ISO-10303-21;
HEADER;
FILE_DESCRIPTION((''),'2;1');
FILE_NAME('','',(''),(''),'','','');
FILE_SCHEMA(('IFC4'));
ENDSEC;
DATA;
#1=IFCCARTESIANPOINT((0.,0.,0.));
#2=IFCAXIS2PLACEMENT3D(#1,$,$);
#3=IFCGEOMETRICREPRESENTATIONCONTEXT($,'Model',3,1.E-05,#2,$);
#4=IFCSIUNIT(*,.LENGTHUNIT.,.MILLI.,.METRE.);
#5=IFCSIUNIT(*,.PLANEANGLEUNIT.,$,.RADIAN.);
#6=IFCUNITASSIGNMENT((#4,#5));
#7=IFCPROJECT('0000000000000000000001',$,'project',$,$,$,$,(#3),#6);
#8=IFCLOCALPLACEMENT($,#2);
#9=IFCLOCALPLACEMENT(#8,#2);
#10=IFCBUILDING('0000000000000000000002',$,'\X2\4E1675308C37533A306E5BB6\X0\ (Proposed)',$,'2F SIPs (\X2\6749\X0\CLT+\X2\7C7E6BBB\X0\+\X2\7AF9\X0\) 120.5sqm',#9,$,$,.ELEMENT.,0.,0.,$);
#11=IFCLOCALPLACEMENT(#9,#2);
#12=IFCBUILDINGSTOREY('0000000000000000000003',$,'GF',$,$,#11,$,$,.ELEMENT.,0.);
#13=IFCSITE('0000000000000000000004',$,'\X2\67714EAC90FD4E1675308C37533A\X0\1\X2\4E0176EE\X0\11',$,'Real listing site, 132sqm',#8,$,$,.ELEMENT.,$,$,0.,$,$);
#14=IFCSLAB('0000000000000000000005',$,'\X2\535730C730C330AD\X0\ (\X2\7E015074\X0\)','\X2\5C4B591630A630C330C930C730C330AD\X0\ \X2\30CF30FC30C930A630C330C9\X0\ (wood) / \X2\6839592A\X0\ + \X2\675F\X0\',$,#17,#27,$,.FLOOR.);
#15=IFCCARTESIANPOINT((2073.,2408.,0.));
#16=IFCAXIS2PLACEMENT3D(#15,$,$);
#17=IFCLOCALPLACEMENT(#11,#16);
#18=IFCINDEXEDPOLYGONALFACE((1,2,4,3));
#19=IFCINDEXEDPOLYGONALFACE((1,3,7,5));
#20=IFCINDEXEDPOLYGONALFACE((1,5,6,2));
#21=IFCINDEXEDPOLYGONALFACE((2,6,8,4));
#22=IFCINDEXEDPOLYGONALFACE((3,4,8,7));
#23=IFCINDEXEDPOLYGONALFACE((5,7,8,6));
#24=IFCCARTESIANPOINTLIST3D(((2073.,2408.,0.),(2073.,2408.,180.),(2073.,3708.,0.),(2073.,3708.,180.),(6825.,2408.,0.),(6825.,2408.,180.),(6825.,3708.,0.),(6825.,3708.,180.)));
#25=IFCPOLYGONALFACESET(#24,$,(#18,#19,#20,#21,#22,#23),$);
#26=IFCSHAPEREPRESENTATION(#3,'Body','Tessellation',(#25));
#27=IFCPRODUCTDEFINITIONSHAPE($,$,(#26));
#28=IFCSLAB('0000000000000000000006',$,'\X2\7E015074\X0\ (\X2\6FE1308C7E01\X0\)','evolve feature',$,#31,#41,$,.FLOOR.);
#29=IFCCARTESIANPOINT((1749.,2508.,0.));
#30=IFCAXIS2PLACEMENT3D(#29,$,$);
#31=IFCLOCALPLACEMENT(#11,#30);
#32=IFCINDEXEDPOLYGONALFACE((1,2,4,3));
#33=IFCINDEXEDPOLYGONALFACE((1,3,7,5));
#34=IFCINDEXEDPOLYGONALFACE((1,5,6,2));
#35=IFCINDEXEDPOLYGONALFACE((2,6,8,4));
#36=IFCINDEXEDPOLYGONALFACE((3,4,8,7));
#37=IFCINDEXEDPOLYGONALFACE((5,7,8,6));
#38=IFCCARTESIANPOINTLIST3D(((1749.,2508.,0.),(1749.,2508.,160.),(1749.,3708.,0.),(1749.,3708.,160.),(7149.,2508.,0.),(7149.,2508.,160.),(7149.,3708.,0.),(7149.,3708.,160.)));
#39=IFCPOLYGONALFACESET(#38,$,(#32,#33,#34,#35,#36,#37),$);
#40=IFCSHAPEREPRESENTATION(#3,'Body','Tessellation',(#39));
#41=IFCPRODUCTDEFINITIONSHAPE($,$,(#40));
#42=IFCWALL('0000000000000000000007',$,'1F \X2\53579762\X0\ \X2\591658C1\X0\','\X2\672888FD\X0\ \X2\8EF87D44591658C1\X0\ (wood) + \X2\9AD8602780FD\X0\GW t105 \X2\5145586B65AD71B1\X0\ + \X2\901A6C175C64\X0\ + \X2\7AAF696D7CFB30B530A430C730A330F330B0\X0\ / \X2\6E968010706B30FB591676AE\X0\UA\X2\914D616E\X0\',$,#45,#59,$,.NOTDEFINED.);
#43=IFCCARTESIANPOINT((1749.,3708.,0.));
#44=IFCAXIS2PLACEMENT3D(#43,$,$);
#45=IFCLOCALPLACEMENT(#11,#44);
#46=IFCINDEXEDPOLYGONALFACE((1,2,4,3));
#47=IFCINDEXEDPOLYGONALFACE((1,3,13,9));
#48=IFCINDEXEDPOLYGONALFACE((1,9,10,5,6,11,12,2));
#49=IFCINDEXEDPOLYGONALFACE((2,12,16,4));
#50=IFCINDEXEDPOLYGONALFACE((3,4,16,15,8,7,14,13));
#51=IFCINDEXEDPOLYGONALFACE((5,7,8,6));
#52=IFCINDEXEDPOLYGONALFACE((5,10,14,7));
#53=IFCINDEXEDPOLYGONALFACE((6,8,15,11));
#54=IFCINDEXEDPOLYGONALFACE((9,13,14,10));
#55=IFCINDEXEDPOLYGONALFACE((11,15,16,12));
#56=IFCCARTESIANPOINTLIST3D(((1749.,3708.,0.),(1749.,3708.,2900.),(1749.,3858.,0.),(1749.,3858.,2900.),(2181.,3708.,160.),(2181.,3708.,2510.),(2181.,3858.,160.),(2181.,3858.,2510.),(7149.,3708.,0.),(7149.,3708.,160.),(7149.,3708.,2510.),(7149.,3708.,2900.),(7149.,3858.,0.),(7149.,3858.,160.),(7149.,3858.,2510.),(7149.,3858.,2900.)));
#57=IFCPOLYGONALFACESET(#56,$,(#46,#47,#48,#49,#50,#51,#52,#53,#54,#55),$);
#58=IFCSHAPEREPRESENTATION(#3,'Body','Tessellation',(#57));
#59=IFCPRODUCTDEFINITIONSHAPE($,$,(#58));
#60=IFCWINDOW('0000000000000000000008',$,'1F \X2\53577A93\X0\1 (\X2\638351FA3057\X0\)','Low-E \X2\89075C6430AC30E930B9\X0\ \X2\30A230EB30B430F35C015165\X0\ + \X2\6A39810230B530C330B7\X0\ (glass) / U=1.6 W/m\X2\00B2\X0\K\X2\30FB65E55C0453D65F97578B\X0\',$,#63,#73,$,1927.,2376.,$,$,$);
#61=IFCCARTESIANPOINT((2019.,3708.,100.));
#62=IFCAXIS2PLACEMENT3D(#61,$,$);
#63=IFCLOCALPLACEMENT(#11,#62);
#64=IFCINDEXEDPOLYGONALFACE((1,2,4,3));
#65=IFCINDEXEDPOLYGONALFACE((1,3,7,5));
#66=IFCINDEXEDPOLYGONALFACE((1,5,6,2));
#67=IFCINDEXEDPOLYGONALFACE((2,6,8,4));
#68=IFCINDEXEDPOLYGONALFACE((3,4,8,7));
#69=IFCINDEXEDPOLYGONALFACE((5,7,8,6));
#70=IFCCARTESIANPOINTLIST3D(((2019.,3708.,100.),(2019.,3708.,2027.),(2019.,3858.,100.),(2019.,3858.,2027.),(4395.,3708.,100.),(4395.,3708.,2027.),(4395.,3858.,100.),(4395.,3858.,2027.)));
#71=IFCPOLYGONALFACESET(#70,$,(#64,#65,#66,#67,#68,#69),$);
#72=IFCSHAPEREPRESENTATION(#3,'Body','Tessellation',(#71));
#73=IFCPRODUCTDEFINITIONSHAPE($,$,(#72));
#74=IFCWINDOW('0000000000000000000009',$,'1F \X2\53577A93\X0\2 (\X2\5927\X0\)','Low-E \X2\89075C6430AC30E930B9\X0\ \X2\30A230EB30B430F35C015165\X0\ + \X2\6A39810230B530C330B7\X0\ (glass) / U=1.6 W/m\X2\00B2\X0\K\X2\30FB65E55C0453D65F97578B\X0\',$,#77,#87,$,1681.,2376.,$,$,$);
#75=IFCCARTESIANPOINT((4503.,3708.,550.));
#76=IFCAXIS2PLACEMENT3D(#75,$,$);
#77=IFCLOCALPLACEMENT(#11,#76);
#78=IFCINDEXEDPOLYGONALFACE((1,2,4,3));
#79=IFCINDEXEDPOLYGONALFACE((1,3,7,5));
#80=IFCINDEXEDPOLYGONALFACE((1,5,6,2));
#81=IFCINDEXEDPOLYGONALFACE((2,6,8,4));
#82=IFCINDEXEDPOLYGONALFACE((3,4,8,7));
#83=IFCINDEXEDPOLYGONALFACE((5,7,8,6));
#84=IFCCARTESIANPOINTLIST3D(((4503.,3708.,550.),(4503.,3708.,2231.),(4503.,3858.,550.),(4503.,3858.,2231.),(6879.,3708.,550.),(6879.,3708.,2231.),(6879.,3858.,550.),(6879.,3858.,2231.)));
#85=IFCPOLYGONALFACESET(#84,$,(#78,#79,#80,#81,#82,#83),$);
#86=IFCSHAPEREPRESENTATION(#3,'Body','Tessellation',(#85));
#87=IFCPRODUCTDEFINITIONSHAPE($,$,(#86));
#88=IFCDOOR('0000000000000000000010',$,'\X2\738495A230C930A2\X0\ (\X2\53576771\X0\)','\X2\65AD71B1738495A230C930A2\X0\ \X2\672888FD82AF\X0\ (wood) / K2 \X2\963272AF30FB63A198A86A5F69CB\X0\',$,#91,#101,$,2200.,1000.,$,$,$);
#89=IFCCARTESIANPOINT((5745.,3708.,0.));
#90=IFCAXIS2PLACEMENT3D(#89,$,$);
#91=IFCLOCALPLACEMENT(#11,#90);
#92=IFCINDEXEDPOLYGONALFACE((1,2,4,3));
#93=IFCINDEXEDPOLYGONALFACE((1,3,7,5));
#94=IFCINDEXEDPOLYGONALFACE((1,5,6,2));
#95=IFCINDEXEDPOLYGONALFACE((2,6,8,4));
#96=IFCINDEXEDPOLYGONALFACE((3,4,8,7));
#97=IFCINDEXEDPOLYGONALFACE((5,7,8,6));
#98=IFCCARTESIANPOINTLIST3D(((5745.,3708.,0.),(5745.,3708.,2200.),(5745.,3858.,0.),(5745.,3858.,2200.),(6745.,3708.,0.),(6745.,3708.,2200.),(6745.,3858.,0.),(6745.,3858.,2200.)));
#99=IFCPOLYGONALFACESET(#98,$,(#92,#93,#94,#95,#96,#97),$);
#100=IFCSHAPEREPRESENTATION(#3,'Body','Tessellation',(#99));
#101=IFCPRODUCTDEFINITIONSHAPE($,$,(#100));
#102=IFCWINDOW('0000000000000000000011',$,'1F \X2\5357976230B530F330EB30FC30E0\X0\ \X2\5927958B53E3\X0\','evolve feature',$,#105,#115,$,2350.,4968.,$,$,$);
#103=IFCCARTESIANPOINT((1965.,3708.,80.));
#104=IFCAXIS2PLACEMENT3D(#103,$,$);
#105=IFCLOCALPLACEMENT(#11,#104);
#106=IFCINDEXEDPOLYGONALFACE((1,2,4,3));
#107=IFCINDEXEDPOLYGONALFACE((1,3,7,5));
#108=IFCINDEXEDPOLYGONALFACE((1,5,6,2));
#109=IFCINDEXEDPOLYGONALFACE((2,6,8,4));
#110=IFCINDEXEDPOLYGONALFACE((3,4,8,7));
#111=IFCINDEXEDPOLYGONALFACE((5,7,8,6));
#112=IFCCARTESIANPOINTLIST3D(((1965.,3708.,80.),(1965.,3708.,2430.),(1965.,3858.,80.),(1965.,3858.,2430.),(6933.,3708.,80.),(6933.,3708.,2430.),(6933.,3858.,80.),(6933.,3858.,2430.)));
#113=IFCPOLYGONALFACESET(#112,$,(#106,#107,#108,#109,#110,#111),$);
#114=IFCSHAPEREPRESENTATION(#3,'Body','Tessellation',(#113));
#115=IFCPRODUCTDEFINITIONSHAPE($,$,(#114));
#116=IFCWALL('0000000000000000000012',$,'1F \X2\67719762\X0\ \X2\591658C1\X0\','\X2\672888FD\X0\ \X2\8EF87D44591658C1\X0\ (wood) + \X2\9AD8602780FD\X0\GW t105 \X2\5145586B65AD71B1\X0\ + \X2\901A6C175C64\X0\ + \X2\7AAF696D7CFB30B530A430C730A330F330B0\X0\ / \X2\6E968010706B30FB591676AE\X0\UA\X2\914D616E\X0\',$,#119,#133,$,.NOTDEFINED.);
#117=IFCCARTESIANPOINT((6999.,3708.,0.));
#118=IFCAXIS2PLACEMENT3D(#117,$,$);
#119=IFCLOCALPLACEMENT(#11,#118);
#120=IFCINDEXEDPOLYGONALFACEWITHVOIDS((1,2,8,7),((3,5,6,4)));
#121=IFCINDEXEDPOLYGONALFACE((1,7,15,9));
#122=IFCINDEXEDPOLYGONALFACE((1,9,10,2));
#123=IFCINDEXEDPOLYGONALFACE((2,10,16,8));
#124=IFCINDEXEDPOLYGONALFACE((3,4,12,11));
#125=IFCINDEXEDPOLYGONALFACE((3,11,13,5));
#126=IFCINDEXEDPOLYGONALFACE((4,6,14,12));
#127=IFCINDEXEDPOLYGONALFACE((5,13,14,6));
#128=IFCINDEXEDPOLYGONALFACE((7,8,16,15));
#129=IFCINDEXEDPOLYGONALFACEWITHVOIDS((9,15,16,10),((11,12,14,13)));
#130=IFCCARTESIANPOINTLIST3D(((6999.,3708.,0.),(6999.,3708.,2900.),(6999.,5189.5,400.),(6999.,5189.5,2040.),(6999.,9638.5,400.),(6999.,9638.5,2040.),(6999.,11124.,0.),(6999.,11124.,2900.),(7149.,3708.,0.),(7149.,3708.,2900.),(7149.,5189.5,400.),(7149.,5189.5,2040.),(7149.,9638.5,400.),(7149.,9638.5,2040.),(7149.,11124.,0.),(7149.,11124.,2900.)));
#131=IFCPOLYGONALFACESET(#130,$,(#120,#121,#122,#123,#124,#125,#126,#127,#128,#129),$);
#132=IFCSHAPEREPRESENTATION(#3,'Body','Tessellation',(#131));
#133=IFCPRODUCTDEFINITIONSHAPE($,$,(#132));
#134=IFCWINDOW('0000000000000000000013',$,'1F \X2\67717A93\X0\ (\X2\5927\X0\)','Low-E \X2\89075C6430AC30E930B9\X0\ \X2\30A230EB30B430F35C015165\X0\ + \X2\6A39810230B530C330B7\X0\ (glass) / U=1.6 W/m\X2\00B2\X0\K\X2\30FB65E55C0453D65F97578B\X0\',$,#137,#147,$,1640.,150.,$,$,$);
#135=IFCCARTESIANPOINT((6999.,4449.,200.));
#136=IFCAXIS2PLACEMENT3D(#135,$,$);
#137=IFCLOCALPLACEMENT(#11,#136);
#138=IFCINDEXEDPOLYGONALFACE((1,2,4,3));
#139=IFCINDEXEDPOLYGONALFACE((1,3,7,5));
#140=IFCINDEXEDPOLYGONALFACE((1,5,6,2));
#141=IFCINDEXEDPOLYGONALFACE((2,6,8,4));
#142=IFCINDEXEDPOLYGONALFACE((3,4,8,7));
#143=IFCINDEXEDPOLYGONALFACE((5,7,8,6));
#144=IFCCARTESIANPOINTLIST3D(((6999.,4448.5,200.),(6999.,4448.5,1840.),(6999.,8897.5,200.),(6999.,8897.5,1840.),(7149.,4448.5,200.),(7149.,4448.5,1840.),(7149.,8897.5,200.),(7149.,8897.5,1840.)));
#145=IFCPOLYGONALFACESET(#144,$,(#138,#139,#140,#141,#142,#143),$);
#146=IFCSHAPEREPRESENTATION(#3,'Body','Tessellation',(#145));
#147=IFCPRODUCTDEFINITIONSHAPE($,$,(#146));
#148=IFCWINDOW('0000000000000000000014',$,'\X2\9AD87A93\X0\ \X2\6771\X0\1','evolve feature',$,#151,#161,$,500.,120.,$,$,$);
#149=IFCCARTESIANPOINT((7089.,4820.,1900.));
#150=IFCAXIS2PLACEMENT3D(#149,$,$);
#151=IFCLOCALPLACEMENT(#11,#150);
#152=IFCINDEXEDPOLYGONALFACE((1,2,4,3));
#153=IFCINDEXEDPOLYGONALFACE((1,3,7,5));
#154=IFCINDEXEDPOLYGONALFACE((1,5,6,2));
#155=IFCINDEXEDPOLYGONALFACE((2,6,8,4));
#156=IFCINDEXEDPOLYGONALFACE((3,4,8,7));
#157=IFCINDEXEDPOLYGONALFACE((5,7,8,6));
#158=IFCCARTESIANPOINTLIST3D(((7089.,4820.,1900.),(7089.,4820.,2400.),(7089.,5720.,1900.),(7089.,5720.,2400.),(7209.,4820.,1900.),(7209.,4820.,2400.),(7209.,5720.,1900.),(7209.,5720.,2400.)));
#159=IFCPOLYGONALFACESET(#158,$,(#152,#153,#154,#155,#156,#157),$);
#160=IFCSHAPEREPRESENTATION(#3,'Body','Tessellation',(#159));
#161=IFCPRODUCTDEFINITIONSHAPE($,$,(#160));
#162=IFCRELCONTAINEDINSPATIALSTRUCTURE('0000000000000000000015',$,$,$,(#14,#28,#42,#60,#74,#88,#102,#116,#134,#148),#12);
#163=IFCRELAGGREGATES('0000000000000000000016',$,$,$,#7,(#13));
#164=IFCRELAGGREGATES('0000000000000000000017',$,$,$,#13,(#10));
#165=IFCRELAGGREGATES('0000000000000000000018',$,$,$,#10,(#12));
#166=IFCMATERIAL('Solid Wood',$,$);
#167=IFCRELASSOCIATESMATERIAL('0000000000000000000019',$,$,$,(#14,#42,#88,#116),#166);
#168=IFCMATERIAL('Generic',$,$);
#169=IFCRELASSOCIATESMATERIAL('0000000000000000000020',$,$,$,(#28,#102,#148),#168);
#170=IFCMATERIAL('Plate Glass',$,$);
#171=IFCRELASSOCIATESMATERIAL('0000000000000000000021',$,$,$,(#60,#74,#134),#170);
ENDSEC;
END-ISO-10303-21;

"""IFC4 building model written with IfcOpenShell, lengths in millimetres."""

from ifc_helpers import new_model, si_unit, frame, frame_2d, origin, place, context, project, spatial, rectangle, extrude, material, element, fill, save


model = new_model("IFC4")

# Units and contexts
model_context = context("Model", 3, precision=1e-05, world=origin())
ifc_project = project(units=[si_unit("LENGTHUNIT", "METRE", prefix="MILLI"), si_unit("PLANEANGLEUNIT", "RADIAN")], contexts=[model_context])

# Site, building, storey
site_placement = place(None, origin())
site = spatial("IfcSite", under=ifc_project, at=site_placement, Name="東京都世田谷区1丁目11", ObjectType="Real listing site, 132sqm", CompositionType="ELEMENT", RefElevation=0.0)
building_placement = place(site_placement, origin())
building = spatial("IfcBuilding", under=site, at=building_placement, Name="世田谷区の家 (Proposed)", ObjectType="2F SIPs (杉CLT+籾殻+竹) 120.5sqm", CompositionType="ELEMENT", ElevationOfRefHeight=0.0, ElevationOfTerrain=0.0)
storey_placement = place(building_placement, origin())
storey = spatial("IfcBuildingStorey", under=building, at=storey_placement, Name="GF", CompositionType="ELEMENT", Elevation=0.0)

# Slabs
ifc_material_1 = material(Name="Solid Wood")
slab_1_placement = place(storey_placement, frame((2073.0, 2408.0, 0.0)))
element("IfcSlab", 1, at=slab_1_placement, inside=storey, material=ifc_material_1, Name="南デッキ (縁側)", Description="屋外ウッドデッキ ハードウッド (wood) / 根太 + 束", PredefinedType="FLOOR", context=model_context, shape_type="SweptSolid", body=[
    extrude(rectangle(XDim=4752.0, YDim=1300.0, at=frame_2d((2376.0, 650.0))), frame((2073.0, 2408.0, 0.0)), (0.0, 0.0, 1.0), 180.0),
])
ifc_material_2 = material(Name="Generic")
slab_2_placement = place(storey_placement, frame((1749.0, 2508.0, 0.0)))
element("IfcSlab", 2, at=slab_2_placement, inside=storey, material=ifc_material_2, Name="縁側 (濡れ縁)", Description="evolve feature", PredefinedType="FLOOR", context=model_context, shape_type="SweptSolid", body=[
    extrude(rectangle(XDim=5400.0, YDim=1200.0, at=frame_2d((2700.0, 600.0))), frame((1749.0, 2508.0, 0.0)), (0.0, 0.0, 1.0), 160.0),
])

# Wall, openings, windows, door
wall_1_placement = place(storey_placement, frame((1749.0, 3708.0, 0.0)))
wall_1 = element("IfcWall", 3, at=wall_1_placement, inside=storey, material=ifc_material_1, Name="1F 南面 外壁", Description="木製 軸組外壁 (wood) + 高性能GW t105 充填断熱 + 通気層 + 窯業系サイディング / 準耐火・外皮UA配慮", PredefinedType="NOTDEFINED", context=model_context, shape_type="SweptSolid", body=[
    extrude(rectangle(XDim=5400.0, YDim=150.0, at=frame_2d((2700.0, 75.0))), frame((1749.0, 3708.0, 0.0)), (0.0, 0.0, 1.0), 2900.0),
])
opening_1_placement = place(storey_placement, frame((2019.0, 3708.0, 100.0)))
opening_1 = element("IfcOpeningElement", 4, at=opening_1_placement, cuts=wall_1, PredefinedType="NOTDEFINED", context=model_context, shape_type="SweptSolid", body=[
    extrude(rectangle(XDim=2376.0, YDim=150.0, at=frame_2d((1188.0, 75.0))), frame((2019.0, 3708.0, 100.0)), (0.0, 0.0, 1.0), 1927.0),
])
opening_2_placement = place(storey_placement, frame((4503.0, 3708.0, 550.0)))
opening_2 = element("IfcOpeningElement", 5, at=opening_2_placement, cuts=wall_1, PredefinedType="NOTDEFINED", context=model_context, shape_type="SweptSolid", body=[
    extrude(rectangle(XDim=2376.0, YDim=150.0, at=frame_2d((1188.0, 75.0))), frame((4503.0, 3708.0, 550.0)), (0.0, 0.0, 1.0), 1681.0),
])
opening_3_placement = place(storey_placement, frame((5745.0, 3708.0, 0.0)))
opening_3 = element("IfcOpeningElement", 6, at=opening_3_placement, cuts=wall_1, PredefinedType="NOTDEFINED", context=model_context, shape_type="SweptSolid", body=[
    extrude(rectangle(XDim=1000.0, YDim=150.0, at=frame_2d((500.0, 75.0))), frame((5745.0, 3708.0, 0.0)), (0.0, 0.0, 1.0), 2200.0),
])
opening_4_placement = place(storey_placement, frame((1965.0, 3708.0, 80.0)))
opening_4 = element("IfcOpeningElement", 7, at=opening_4_placement, cuts=wall_1, PredefinedType="NOTDEFINED", context=model_context, shape_type="SweptSolid", body=[
    extrude(rectangle(XDim=4968.0, YDim=150.0, at=frame_2d((2484.0, 75.0))), frame((1965.0, 3708.0, 80.0)), (0.0, 0.0, 1.0), 2350.0),
])
ifc_material_3 = material(Name="Plate Glass")
window_1_placement = place(storey_placement, frame((2019.0, 3708.0, 100.0)))
window_1 = element("IfcWindow", 8, at=window_1_placement, inside=storey, material=ifc_material_3, Name="1F 南窓1 (掃出し)", Description="Low-E 複層ガラス アルゴン封入 + 樹脂サッシ (glass) / U=1.6 W/m²K・日射取得型", OverallHeight=1927.0, OverallWidth=2376.0, context=model_context, shape_type="SweptSolid", body=[
    extrude(rectangle(XDim=2376.0, YDim=150.0, at=frame_2d((1188.0, 75.0))), frame((2019.0, 3708.0, 100.0)), (0.0, 0.0, 1.0), 1927.0),
])
fill(opening_1, window_1)
window_2_placement = place(storey_placement, frame((4503.0, 3708.0, 550.0)))
window_2 = element("IfcWindow", 9, at=window_2_placement, inside=storey, material=ifc_material_3, Name="1F 南窓2 (大)", Description="Low-E 複層ガラス アルゴン封入 + 樹脂サッシ (glass) / U=1.6 W/m²K・日射取得型", OverallHeight=1681.0, OverallWidth=2376.0, context=model_context, shape_type="SweptSolid", body=[
    extrude(rectangle(XDim=2376.0, YDim=150.0, at=frame_2d((1188.0, 75.0))), frame((4503.0, 3708.0, 550.0)), (0.0, 0.0, 1.0), 1681.0),
])
fill(opening_2, window_2)
door_placement = place(storey_placement, frame((5745.0, 3708.0, 0.0)))
door = element("IfcDoor", 10, at=door_placement, inside=storey, material=ifc_material_1, Name="玄関ドア (南東)", Description="断熱玄関ドア 木製芯 (wood) / K2 防犯・採風機構", OverallHeight=2200.0, OverallWidth=1000.0, context=model_context, shape_type="SweptSolid", body=[
    extrude(rectangle(XDim=1000.0, YDim=150.0, at=frame_2d((500.0, 75.0))), frame((5745.0, 3708.0, 0.0)), (0.0, 0.0, 1.0), 2200.0),
])
fill(opening_3, door)
window_3_placement = place(storey_placement, frame((1965.0, 3708.0, 80.0)))
window_3 = element("IfcWindow", 11, at=window_3_placement, inside=storey, material=ifc_material_2, Name="1F 南面サンルーム 大開口", Description="evolve feature", OverallHeight=2350.0, OverallWidth=4968.0, context=model_context, shape_type="SweptSolid", body=[
    extrude(rectangle(XDim=4968.0, YDim=150.0, at=frame_2d((2484.0, 75.0))), frame((1965.0, 3708.0, 80.0)), (0.0, 0.0, 1.0), 2350.0),
])
fill(opening_4, window_3)

# Wall, openings, windows
wall_2_placement = place(storey_placement, frame((6999.0, 3708.0, 0.0)))
wall_2 = element("IfcWall", 12, at=wall_2_placement, inside=storey, material=ifc_material_1, Name="1F 東面 外壁", Description="木製 軸組外壁 (wood) + 高性能GW t105 充填断熱 + 通気層 + 窯業系サイディング / 準耐火・外皮UA配慮", PredefinedType="NOTDEFINED", context=model_context, shape_type="SweptSolid", body=[
    extrude(rectangle(XDim=150.0, YDim=7416.0, at=frame_2d((75.0, 3708.0))), frame((6999.0, 3708.0, 0.0)), (0.0, 0.0, 1.0), 2900.0),
])
opening_5_placement = place(storey_placement, frame((6999.0, 4449.0, 200.0)))
opening_5 = element("IfcOpeningElement", 13, at=opening_5_placement, cuts=wall_2, PredefinedType="NOTDEFINED", context=model_context, shape_type="SweptSolid", body=[
    extrude(rectangle(XDim=150.0, YDim=4449.0, at=frame_2d((75.0, 2224.0))), frame((6999.0, 4449.0, 200.0)), (0.0, 0.0, 1.0), 1640.0),
])
opening_6_placement = place(storey_placement, frame((7089.0, 4820.0, 1900.0)))
opening_6 = element("IfcOpeningElement", 14, at=opening_6_placement, cuts=wall_2, PredefinedType="NOTDEFINED", context=model_context, shape_type="SweptSolid", body=[
    extrude(rectangle(XDim=120.0, YDim=900.0, at=frame_2d((60.0, 450.0))), frame((7089.0, 4820.0, 1900.0)), (0.0, 0.0, 1.0), 500.0),
])
window_4_placement = place(storey_placement, frame((6999.0, 4449.0, 200.0)))
window_4 = element("IfcWindow", 15, at=window_4_placement, inside=storey, material=ifc_material_3, Name="1F 東窓 (大)", Description="Low-E 複層ガラス アルゴン封入 + 樹脂サッシ (glass) / U=1.6 W/m²K・日射取得型", OverallHeight=1640.0, OverallWidth=150.0, context=model_context, shape_type="SweptSolid", body=[
    extrude(rectangle(XDim=150.0, YDim=4449.0, at=frame_2d((75.0, 2224.0))), frame((6999.0, 4449.0, 200.0)), (0.0, 0.0, 1.0), 1640.0),
])
fill(opening_5, window_4)
window_5_placement = place(storey_placement, frame((7089.0, 4820.0, 1900.0)))
window_5 = element("IfcWindow", 16, at=window_5_placement, inside=storey, material=ifc_material_2, Name="高窓 東1", Description="evolve feature", OverallHeight=500.0, OverallWidth=120.0, context=model_context, shape_type="SweptSolid", body=[
    extrude(rectangle(XDim=120.0, YDim=900.0, at=frame_2d((60.0, 450.0))), frame((7089.0, 4820.0, 1900.0)), (0.0, 0.0, 1.0), 500.0),
])
fill(opening_6, window_5)

save(model, "model.ifc")
